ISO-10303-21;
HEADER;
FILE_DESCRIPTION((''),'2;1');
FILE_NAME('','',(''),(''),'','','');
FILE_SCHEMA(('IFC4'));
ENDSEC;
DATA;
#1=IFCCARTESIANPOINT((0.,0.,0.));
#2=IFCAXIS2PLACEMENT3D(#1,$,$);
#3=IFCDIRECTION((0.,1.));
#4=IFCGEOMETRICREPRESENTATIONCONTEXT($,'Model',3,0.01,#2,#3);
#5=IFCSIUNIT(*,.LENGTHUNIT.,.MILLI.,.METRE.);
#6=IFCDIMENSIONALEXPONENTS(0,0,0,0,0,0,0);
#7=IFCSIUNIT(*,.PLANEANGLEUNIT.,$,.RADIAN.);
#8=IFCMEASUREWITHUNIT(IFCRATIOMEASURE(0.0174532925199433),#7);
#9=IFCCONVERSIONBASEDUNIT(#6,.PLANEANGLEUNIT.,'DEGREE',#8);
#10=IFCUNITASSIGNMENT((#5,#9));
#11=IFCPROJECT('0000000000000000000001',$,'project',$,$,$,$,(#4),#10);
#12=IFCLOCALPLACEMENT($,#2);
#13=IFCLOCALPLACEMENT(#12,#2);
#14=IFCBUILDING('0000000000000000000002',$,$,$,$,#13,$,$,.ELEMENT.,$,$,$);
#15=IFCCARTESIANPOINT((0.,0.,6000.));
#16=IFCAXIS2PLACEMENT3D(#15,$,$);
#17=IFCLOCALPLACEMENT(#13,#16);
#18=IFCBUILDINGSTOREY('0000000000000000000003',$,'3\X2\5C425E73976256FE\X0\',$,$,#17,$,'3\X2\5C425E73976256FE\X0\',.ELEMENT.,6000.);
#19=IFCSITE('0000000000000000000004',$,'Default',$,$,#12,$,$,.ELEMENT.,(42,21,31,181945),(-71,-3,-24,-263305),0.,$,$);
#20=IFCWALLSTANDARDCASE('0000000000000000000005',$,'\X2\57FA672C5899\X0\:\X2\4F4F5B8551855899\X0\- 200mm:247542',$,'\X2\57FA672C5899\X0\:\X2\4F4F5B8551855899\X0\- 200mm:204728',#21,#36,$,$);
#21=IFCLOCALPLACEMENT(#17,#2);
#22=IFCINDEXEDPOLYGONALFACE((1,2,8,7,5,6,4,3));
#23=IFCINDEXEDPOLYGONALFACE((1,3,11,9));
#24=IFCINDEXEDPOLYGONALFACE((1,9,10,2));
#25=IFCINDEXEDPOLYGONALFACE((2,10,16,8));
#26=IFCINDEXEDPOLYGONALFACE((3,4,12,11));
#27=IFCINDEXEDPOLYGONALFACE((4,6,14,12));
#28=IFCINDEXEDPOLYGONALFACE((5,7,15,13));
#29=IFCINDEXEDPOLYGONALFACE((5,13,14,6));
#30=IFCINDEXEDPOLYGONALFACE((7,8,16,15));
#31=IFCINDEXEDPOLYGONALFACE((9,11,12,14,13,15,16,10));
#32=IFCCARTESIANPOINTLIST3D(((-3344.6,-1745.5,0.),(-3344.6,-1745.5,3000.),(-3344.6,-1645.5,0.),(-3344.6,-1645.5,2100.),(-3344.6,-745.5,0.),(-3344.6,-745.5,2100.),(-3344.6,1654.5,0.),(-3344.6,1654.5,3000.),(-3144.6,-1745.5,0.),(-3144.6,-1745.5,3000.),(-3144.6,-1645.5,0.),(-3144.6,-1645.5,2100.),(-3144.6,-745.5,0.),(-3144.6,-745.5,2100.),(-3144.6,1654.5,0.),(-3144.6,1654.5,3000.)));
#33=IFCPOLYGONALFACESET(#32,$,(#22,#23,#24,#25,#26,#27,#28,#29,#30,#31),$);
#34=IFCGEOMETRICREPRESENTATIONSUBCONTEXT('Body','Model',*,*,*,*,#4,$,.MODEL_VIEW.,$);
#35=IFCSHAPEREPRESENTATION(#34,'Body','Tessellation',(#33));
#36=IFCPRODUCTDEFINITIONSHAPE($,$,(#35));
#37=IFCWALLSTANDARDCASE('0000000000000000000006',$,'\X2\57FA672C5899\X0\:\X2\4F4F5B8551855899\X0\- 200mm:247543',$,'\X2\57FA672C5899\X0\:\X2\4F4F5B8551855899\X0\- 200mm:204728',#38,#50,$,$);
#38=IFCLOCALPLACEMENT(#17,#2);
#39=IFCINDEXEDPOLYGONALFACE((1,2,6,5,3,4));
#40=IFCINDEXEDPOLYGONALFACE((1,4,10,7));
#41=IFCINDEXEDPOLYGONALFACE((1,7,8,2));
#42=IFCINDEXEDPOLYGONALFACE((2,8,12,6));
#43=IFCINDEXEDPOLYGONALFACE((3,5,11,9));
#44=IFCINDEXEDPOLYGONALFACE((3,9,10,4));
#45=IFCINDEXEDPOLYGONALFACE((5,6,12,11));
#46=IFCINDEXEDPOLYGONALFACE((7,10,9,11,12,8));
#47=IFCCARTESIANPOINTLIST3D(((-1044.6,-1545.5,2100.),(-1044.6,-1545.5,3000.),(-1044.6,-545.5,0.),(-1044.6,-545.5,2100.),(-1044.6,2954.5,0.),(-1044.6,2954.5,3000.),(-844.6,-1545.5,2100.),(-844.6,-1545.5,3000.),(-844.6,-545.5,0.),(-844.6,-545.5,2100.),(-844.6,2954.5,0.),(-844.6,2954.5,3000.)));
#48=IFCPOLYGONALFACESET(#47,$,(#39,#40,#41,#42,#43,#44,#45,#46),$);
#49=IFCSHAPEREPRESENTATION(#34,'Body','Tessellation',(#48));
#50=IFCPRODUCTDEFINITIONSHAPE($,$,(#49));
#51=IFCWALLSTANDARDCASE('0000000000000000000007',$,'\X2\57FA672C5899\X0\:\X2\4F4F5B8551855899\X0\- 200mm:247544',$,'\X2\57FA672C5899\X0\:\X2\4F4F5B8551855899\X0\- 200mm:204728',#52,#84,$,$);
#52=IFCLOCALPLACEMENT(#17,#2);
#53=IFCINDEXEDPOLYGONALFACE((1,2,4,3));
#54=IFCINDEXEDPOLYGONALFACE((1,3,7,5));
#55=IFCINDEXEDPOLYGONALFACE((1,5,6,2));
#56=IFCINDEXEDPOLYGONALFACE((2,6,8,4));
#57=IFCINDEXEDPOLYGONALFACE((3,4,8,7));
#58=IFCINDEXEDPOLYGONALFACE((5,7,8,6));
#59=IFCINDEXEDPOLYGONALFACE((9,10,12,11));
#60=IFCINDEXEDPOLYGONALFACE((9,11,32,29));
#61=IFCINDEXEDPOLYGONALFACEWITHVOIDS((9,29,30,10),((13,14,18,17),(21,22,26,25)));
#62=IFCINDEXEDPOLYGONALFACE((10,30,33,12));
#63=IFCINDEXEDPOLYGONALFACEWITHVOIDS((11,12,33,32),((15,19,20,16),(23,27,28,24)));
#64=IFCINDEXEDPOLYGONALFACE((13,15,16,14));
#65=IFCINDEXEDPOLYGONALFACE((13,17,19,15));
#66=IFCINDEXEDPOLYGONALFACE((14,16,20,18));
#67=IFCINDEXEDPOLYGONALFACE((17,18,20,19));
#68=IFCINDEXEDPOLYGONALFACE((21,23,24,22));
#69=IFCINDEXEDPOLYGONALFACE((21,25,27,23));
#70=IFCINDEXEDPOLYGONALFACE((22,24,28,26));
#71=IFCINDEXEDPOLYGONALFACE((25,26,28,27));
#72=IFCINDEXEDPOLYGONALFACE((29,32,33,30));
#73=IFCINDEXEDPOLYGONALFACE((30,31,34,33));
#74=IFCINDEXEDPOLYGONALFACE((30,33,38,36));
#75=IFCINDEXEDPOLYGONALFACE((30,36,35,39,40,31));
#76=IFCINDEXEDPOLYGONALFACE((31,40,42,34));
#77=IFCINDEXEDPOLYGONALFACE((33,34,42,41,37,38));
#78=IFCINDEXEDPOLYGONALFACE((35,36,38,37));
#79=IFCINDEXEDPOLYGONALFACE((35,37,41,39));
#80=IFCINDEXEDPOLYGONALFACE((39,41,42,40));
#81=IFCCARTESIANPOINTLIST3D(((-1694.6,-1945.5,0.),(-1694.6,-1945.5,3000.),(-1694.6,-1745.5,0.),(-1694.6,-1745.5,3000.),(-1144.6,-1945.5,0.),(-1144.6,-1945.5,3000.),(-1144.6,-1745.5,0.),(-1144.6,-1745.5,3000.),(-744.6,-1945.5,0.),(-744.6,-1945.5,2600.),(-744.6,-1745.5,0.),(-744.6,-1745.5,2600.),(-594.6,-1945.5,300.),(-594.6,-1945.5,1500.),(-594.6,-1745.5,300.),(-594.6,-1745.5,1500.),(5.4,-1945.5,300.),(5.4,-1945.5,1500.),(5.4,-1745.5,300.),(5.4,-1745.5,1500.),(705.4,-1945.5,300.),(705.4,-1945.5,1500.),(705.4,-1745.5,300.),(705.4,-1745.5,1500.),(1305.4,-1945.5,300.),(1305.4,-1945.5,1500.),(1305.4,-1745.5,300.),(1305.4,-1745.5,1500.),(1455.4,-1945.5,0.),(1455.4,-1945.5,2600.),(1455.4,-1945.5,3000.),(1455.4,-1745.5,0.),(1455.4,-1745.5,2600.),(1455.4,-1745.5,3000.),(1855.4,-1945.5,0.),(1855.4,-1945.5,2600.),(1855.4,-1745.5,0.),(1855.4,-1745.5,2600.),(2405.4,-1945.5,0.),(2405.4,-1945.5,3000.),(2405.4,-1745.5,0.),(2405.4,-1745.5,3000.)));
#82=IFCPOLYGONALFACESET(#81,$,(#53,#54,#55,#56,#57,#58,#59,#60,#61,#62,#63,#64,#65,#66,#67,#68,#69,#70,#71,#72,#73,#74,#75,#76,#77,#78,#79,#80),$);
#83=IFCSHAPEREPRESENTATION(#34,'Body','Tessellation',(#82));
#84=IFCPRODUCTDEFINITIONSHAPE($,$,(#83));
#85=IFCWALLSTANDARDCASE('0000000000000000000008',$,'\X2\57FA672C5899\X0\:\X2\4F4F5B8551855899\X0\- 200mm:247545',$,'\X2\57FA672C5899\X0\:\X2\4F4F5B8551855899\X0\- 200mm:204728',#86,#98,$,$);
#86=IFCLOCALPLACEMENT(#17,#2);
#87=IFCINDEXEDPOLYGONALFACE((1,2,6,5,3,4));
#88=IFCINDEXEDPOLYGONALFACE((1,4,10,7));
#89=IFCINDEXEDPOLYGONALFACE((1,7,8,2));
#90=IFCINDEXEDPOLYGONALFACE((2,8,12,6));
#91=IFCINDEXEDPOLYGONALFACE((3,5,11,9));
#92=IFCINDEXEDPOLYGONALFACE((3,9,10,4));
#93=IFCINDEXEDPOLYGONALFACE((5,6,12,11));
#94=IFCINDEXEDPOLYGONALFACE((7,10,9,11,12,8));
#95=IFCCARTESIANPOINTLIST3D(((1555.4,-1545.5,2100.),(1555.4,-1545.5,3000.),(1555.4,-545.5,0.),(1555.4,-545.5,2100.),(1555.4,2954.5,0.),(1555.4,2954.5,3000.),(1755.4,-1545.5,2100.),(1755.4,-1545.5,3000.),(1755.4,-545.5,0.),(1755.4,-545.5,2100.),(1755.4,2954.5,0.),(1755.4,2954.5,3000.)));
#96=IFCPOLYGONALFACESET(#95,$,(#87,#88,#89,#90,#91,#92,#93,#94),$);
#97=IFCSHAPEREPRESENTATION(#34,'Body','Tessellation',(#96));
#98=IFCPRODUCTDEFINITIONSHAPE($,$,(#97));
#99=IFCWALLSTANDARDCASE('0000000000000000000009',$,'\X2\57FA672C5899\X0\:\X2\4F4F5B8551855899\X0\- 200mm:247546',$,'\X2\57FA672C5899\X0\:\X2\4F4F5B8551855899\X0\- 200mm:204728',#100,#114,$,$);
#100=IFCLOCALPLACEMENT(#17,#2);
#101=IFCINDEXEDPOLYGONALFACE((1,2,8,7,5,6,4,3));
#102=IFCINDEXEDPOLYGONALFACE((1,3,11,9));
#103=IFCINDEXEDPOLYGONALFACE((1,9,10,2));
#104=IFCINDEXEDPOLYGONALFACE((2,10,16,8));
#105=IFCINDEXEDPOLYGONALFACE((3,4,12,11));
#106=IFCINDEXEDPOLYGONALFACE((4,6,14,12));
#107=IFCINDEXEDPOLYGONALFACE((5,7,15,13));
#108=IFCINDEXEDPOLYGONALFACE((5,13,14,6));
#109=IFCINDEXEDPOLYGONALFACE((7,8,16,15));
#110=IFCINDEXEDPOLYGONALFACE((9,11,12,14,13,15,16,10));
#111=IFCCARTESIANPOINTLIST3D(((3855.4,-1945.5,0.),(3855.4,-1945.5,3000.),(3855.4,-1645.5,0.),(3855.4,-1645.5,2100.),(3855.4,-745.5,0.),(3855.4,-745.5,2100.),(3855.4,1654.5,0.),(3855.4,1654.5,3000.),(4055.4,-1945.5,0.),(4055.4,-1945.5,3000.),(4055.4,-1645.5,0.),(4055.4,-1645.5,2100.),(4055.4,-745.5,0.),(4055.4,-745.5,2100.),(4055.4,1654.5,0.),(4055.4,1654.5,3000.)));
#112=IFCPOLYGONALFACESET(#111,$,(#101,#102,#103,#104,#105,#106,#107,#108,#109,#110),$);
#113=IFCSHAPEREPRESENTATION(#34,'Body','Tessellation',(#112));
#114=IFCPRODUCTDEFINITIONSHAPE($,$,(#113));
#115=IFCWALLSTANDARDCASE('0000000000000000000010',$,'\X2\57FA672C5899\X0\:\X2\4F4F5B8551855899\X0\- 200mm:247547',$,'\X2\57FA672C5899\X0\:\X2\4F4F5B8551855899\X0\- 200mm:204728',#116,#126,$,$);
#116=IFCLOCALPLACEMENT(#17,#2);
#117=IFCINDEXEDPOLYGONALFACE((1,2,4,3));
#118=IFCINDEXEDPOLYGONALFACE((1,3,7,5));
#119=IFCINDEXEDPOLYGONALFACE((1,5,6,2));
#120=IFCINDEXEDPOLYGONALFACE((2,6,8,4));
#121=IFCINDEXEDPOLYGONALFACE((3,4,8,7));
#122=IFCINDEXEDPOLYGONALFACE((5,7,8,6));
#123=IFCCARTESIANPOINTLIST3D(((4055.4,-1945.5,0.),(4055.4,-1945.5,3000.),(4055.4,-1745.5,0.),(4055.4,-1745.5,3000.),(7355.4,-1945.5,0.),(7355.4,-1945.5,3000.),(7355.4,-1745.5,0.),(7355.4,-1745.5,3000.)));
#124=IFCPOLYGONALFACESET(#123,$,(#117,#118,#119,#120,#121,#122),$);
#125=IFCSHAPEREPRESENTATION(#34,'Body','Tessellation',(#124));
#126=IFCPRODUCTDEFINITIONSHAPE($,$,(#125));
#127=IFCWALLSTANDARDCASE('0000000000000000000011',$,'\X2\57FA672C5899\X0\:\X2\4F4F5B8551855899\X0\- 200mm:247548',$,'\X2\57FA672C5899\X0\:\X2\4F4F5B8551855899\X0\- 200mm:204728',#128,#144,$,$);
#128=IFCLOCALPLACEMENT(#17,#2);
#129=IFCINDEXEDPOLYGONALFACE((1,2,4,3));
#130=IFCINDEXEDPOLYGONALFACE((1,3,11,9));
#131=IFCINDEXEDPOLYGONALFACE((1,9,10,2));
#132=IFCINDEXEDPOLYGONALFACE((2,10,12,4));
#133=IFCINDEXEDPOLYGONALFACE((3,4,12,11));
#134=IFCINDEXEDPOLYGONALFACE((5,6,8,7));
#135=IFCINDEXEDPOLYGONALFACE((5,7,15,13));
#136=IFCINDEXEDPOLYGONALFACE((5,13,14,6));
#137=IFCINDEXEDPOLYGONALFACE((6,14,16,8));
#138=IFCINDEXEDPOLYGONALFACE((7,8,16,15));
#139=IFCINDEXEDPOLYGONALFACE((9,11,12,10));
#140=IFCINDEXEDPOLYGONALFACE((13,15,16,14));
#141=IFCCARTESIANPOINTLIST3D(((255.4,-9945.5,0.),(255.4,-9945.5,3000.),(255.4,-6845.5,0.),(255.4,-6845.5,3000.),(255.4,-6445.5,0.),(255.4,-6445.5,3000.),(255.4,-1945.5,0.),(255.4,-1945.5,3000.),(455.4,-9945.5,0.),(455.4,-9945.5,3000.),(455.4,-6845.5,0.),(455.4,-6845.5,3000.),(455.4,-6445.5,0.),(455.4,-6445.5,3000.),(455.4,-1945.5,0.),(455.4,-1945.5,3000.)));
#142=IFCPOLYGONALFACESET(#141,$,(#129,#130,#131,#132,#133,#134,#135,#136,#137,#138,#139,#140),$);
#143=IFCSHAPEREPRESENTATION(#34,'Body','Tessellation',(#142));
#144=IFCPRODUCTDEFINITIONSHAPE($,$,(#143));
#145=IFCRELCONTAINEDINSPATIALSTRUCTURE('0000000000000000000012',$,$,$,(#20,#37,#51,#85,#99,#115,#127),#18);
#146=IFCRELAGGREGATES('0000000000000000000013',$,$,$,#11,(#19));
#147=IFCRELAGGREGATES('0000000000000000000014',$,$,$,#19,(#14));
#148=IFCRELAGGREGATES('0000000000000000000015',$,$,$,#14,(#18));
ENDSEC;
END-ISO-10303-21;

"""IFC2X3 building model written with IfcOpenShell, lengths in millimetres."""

from ifc_helpers import new_model, entity, si_unit, converted_unit, direction, frame, frame_2d, origin, place, context, subcontext, project, spatial, polyline, rectangle, extrude, clip, bounded_halfspace, element, save


model = new_model("IFC2X3")

# Units and contexts
model_context = context("Model", 3, precision=0.01, world=origin(), true_north=direction((0.0, 1.0)))
body_context = subcontext(model_context, "Body", "Model", "MODEL_VIEW")
ifc_project = project(units=[si_unit("LENGTHUNIT", "METRE", prefix="MILLI"), converted_unit("PLANEANGLEUNIT", "DEGREE", entity("IfcRatioMeasure", 0.0174532925199433), si_unit("PLANEANGLEUNIT", "RADIAN"), dimensions=[0, 0, 0, 0, 0, 0, 0])], contexts=[model_context])

# Site, building, storey
site_placement = place(None, origin())
site = spatial("IfcSite", under=ifc_project, at=site_placement, Name="Default", CompositionType="ELEMENT", RefLatitude=(42, 21, 31, 181945), RefLongitude=(-71, -3, -24, -263305), RefElevation=0.0)
building_placement = place(site_placement, origin())
building = spatial("IfcBuilding", under=site, at=building_placement, CompositionType="ELEMENT")
storey_placement = place(building_placement, frame((0.0, 0.0, 6000.0)))
storey = spatial("IfcBuildingStorey", under=building, at=storey_placement, Name="3层平面图", LongName="3层平面图", CompositionType="ELEMENT", Elevation=6000.0)

# Walls, openings
wall_1_placement = place(storey_placement, frame((-3244.6, -1745.5, 0.0), z_axis=(0.0, 0.0, 1.0), x_axis=(0.0, 1.0, 0.0)))
wall_1 = element("IfcWallStandardCase", 1, at=wall_1_placement, inside=storey, Name="基本墙:住宅内墙- 200mm:247542", ObjectType="基本墙:住宅内墙- 200mm:204728", context=body_context, shape_type="SweptSolid", body=[
    extrude(rectangle(XDim=3400.0, YDim=200.0, at=frame_2d((1700.0, 0.0), x_axis=(-1.0, 0.0))), origin(), (0.0, 0.0, 1.0), 3000.0),
])
opening_1_placement = place(wall_1_placement, frame((100.0, -100.0, 0.0)))
element("IfcOpeningElement", 2, at=opening_1_placement, cuts=wall_1, ObjectType="Opening", context=body_context, shape_type="SweptSolid", body=[
    extrude(rectangle(XDim=2100.0, YDim=900.0, at=frame_2d((1050.0, 450.0), x_axis=(1.0, 0.0))), frame((0.0, 0.0, 0.0), z_axis=(0.0, 1.0, 0.0), x_axis=(0.0, 0.0, 1.0)), (0.0, 0.0, 1.0), 200.0),
])
wall_2_placement = place(storey_placement, frame((-944.6, 2954.5, 0.0), z_axis=(0.0, 0.0, 1.0), x_axis=(0.0, -1.0, 0.0)))
wall_2 = element("IfcWallStandardCase", 3, at=wall_2_placement, inside=storey, Name="基本墙:住宅内墙- 200mm:247543", ObjectType="基本墙:住宅内墙- 200mm:204728", context=body_context, shape_type="Clipping", body=[
    clip(clip(extrude(rectangle(XDim=4500.0, YDim=200.0, at=frame_2d((2250.0, 0.0), x_axis=(-1.0, 0.0))), origin(), (0.0, 0.0, 1.0), 3000.0), bounded_halfspace(frame((4500.0, -100.0, 3000.0), z_axis=(-1.0, 0.0, 0.0), x_axis=(0.0, 0.0, -1.0)), True, frame((4500.0, -100.0, 3000.0), z_axis=(-1.0, 0.0, 0.0), x_axis=(0.0, 0.0, -1.0)), polyline([(0.0, 0.0), (0.0, -200.0), (900.0, -200.0), (900.0, 0.0), (0.0, 0.0)]))), bounded_halfspace(frame((0.0, -100.0, 0.0), z_axis=(1.0, 0.0, 0.0), x_axis=(0.0, 0.0, -1.0)), True, frame((0.0, -100.0, 0.0), z_axis=(1.0, 0.0, 0.0), x_axis=(0.0, 0.0, -1.0)), polyline([(0.0, 0.0), (0.0, 200.0), (-3000.0, 200.0), (-3000.0, 0.0), (0.0, 0.0)]))),
])
opening_2_placement = place(wall_2_placement, frame((3500.0, -100.0, 0.0)))
element("IfcOpeningElement", 4, at=opening_2_placement, cuts=wall_2, ObjectType="Opening", context=body_context, shape_type="SweptSolid", body=[
    extrude(rectangle(XDim=2100.0, YDim=1000.0, at=frame_2d((1050.0, 500.0), x_axis=(1.0, 0.0))), frame((0.0, 0.0, 0.0), z_axis=(0.0, 1.0, 0.0), x_axis=(0.0, 0.0, 1.0)), (0.0, 0.0, 1.0), 200.0),
])

# Wall, openings
wall_3_placement = place(storey_placement, frame((-1694.6, -1845.5, 0.0)))
wall_3 = element("IfcWallStandardCase", 5, at=wall_3_placement, inside=storey, Name="基本墙:住宅内墙- 200mm:247544", ObjectType="基本墙:住宅内墙- 200mm:204728", context=body_context, shape_type="Clipping", body=[
    clip(extrude(rectangle(XDim=4100.0, YDim=200.0, at=frame_2d((2050.0, 0.0), x_axis=(-1.0, 0.0))), origin(), (0.0, 0.0, 1.0), 3000.0), bounded_halfspace(frame((950.0, -100.0, 2600.0), z_axis=(0.0, 0.0, -1.0), x_axis=(-1.0, 0.0, 0.0)), True, frame((950.0, -100.0, 2600.0), z_axis=(0.0, 0.0, -1.0), x_axis=(-1.0, 0.0, 0.0)), polyline([(0.0, 0.0), (0.0, 200.0), (-2200.0, 200.0), (-2200.0, 0.0), (0.0, 0.0)]))),
])
opening_3_placement = place(wall_3_placement, frame((3000.0, 100.0, 300.0)))
element("IfcOpeningElement", 6, at=opening_3_placement, cuts=wall_3, ObjectType="Opening", context=body_context, shape_type="SweptSolid", body=[
    extrude(rectangle(XDim=1200.0, YDim=600.0, at=frame_2d((600.0, 300.0), x_axis=(-1.0, 0.0))), frame((0.0, 0.0, 0.0), z_axis=(0.0, -1.0, 0.0), x_axis=(0.0, 0.0, 1.0)), (0.0, 0.0, 1.0), 200.0),
])
opening_4_placement = place(wall_3_placement, frame((1700.0, 100.0, 300.0)))
element("IfcOpeningElement", 7, at=opening_4_placement, cuts=wall_3, ObjectType="Opening", context=body_context, shape_type="SweptSolid", body=[
    extrude(rectangle(XDim=1200.0, YDim=600.0, at=frame_2d((600.0, 300.0), x_axis=(-1.0, 0.0))), frame((0.0, 0.0, 0.0), z_axis=(0.0, -1.0, 0.0), x_axis=(0.0, 0.0, 1.0)), (0.0, 0.0, 1.0), 200.0),
])
opening_5_placement = place(storey_placement, frame((-1694.6, -1845.5, 0.0)))
element("IfcOpeningElement", 8, at=opening_5_placement, cuts=wall_3, ObjectType="Opening", context=body_context, shape_type="SweptSolid", body=[
    extrude(rectangle(XDim=2600.0, YDim=200.0, at=frame_2d((0.0, 0.0), x_axis=(0.0, 1.0))), frame((3150.0, 0.0, 1300.0), z_axis=(1.0, 0.0, 0.0), x_axis=(0.0, 1.0, 0.0)), (0.0, 0.0, 1.0), 400.0),
])
opening_6_placement = place(storey_placement, frame((-1694.6, -1845.5, 0.0)))
element("IfcOpeningElement", 9, at=opening_6_placement, cuts=wall_3, ObjectType="Opening", context=body_context, shape_type="SweptSolid", body=[
    extrude(rectangle(XDim=3000.0, YDim=200.0, at=frame_2d((0.0, 0.0), x_axis=(1.0, 0.0))), frame((550.0, 0.0, 1500.0), z_axis=(1.0, 0.0, 0.0), x_axis=(0.0, 0.0, -1.0)), (0.0, 0.0, 1.0), 400.0),
])

# Walls, openings
wall_4_placement = place(storey_placement, frame((1655.4, -1545.5, 0.0), z_axis=(0.0, 0.0, 1.0), x_axis=(0.0, 1.0, 0.0)))
wall_4 = element("IfcWallStandardCase", 10, at=wall_4_placement, inside=storey, Name="基本墙:住宅内墙- 200mm:247545", ObjectType="基本墙:住宅内墙- 200mm:204728", context=body_context, shape_type="Clipping", body=[
    clip(clip(extrude(rectangle(XDim=4500.0, YDim=200.0, at=frame_2d((2250.0, 0.0), x_axis=(-1.0, 0.0))), origin(), (0.0, 0.0, 1.0), 3000.0), bounded_halfspace(frame((0.0, -100.0, 2100.0), z_axis=(-1.0, 0.0, 0.0), x_axis=(0.0, 0.0, -1.0)), False, frame((0.0, -100.0, 2100.0), z_axis=(-1.0, 0.0, 0.0), x_axis=(0.0, 0.0, -1.0)), polyline([(0.0, 0.0), (-900.0, 0.0), (-900.0, -200.0), (0.0, -200.0), (0.0, 0.0)]))), bounded_halfspace(frame((4500.0, -100.0, 3000.0), z_axis=(1.0, 0.0, 0.0), x_axis=(0.0, 0.0, -1.0)), False, frame((4500.0, -100.0, 3000.0), z_axis=(1.0, 0.0, 0.0), x_axis=(0.0, 0.0, -1.0)), polyline([(0.0, 0.0), (3000.0, 0.0), (3000.0, 200.0), (0.0, 200.0), (0.0, 0.0)]))),
])
opening_7_placement = place(wall_4_placement, frame((0.0, -100.0, 0.0)))
element("IfcOpeningElement", 11, at=opening_7_placement, cuts=wall_4, ObjectType="Opening", context=body_context, shape_type="SweptSolid", body=[
    extrude(rectangle(XDim=2100.0, YDim=1000.0, at=frame_2d((1050.0, 500.0), x_axis=(1.0, 0.0))), frame((0.0, 0.0, 0.0), z_axis=(0.0, 1.0, 0.0), x_axis=(0.0, 0.0, 1.0)), (0.0, 0.0, 1.0), 200.0),
])
wall_5_placement = place(storey_placement, frame((3955.4, 1654.5, 0.0), z_axis=(0.0, 0.0, 1.0), x_axis=(0.0, -1.0, 0.0)))
wall_5 = element("IfcWallStandardCase", 12, at=wall_5_placement, inside=storey, Name="基本墙:住宅内墙- 200mm:247546", ObjectType="基本墙:住宅内墙- 200mm:204728", context=body_context, shape_type="SweptSolid", body=[
    extrude(rectangle(XDim=3600.0, YDim=200.0, at=frame_2d((1800.0, 0.0), x_axis=(-1.0, 0.0))), origin(), (0.0, 0.0, 1.0), 3000.0),
])
opening_8_placement = place(wall_5_placement, frame((2400.0, -100.0, 0.0)))
element("IfcOpeningElement", 13, at=opening_8_placement, cuts=wall_5, ObjectType="Opening", context=body_context, shape_type="SweptSolid", body=[
    extrude(rectangle(XDim=2100.0, YDim=900.0, at=frame_2d((1050.0, 450.0), x_axis=(1.0, 0.0))), frame((0.0, 0.0, 0.0), z_axis=(0.0, 1.0, 0.0), x_axis=(0.0, 0.0, 1.0)), (0.0, 0.0, 1.0), 200.0),
])

# Wall
wall_6_placement = place(storey_placement, frame((4055.4, -1845.5, 0.0)))
element("IfcWallStandardCase", 14, at=wall_6_placement, inside=storey, Name="基本墙:住宅内墙- 200mm:247547", ObjectType="基本墙:住宅内墙- 200mm:204728", context=body_context, shape_type="Clipping", body=[
    clip(extrude(rectangle(XDim=3300.0, YDim=200.0, at=frame_2d((1650.0, 0.0), x_axis=(-1.0, 0.0))), origin(), (0.0, 0.0, 1.0), 3000.0), bounded_halfspace(frame((3300.0, -100.0, 3000.0), z_axis=(1.0, 0.0, 0.0), x_axis=(0.0, 0.0, -1.0)), False, frame((3300.0, -100.0, 3000.0), z_axis=(1.0, 0.0, 0.0), x_axis=(0.0, 0.0, -1.0)), polyline([(0.0, 0.0), (3000.0, 0.0), (3000.0, 200.0), (0.0, 200.0), (0.0, 0.0)]))),
])

# Wall, opening
wall_7_placement = place(storey_placement, frame((355.4, -1945.5, 0.0), z_axis=(0.0, 0.0, 1.0), x_axis=(0.0, -1.0, 0.0)))
wall_7 = element("IfcWallStandardCase", 15, at=wall_7_placement, inside=storey, Name="基本墙:住宅内墙- 200mm:247548", ObjectType="基本墙:住宅内墙- 200mm:204728", context=body_context, shape_type="Clipping", body=[
    clip(extrude(rectangle(XDim=8000.0, YDim=200.0, at=frame_2d((4000.0, 0.0), x_axis=(-1.0, 0.0))), origin(), (0.0, 0.0, 1.0), 3000.0), bounded_halfspace(frame((8000.0, -100.0, 3000.0), z_axis=(-1.0, 0.0, 0.0), x_axis=(0.0, 0.0, -1.0)), True, frame((8000.0, -100.0, 3000.0), z_axis=(-1.0, 0.0, 0.0), x_axis=(0.0, 0.0, -1.0)), polyline([(0.0, 0.0), (0.0, -200.0), (3000.0, -200.0), (3000.0, 0.0), (0.0, 0.0)]))),
])
opening_9_placement = place(storey_placement, frame((355.4, -1945.5, 0.0), z_axis=(0.0, 0.0, 1.0), x_axis=(0.0, -1.0, 0.0)))
element("IfcOpeningElement", 16, at=opening_9_placement, cuts=wall_7, ObjectType="Opening", context=body_context, shape_type="SweptSolid", body=[
    extrude(rectangle(XDim=3000.0, YDim=200.0, at=frame_2d((0.0, 0.0), x_axis=(1.0, 0.0))), frame((4900.0, 0.0, 1500.0), z_axis=(-1.0, 0.0, 0.0), x_axis=(0.0, 0.0, 1.0)), (0.0, 0.0, 1.0), 400.0),
])

save(model, "model.ifc")
